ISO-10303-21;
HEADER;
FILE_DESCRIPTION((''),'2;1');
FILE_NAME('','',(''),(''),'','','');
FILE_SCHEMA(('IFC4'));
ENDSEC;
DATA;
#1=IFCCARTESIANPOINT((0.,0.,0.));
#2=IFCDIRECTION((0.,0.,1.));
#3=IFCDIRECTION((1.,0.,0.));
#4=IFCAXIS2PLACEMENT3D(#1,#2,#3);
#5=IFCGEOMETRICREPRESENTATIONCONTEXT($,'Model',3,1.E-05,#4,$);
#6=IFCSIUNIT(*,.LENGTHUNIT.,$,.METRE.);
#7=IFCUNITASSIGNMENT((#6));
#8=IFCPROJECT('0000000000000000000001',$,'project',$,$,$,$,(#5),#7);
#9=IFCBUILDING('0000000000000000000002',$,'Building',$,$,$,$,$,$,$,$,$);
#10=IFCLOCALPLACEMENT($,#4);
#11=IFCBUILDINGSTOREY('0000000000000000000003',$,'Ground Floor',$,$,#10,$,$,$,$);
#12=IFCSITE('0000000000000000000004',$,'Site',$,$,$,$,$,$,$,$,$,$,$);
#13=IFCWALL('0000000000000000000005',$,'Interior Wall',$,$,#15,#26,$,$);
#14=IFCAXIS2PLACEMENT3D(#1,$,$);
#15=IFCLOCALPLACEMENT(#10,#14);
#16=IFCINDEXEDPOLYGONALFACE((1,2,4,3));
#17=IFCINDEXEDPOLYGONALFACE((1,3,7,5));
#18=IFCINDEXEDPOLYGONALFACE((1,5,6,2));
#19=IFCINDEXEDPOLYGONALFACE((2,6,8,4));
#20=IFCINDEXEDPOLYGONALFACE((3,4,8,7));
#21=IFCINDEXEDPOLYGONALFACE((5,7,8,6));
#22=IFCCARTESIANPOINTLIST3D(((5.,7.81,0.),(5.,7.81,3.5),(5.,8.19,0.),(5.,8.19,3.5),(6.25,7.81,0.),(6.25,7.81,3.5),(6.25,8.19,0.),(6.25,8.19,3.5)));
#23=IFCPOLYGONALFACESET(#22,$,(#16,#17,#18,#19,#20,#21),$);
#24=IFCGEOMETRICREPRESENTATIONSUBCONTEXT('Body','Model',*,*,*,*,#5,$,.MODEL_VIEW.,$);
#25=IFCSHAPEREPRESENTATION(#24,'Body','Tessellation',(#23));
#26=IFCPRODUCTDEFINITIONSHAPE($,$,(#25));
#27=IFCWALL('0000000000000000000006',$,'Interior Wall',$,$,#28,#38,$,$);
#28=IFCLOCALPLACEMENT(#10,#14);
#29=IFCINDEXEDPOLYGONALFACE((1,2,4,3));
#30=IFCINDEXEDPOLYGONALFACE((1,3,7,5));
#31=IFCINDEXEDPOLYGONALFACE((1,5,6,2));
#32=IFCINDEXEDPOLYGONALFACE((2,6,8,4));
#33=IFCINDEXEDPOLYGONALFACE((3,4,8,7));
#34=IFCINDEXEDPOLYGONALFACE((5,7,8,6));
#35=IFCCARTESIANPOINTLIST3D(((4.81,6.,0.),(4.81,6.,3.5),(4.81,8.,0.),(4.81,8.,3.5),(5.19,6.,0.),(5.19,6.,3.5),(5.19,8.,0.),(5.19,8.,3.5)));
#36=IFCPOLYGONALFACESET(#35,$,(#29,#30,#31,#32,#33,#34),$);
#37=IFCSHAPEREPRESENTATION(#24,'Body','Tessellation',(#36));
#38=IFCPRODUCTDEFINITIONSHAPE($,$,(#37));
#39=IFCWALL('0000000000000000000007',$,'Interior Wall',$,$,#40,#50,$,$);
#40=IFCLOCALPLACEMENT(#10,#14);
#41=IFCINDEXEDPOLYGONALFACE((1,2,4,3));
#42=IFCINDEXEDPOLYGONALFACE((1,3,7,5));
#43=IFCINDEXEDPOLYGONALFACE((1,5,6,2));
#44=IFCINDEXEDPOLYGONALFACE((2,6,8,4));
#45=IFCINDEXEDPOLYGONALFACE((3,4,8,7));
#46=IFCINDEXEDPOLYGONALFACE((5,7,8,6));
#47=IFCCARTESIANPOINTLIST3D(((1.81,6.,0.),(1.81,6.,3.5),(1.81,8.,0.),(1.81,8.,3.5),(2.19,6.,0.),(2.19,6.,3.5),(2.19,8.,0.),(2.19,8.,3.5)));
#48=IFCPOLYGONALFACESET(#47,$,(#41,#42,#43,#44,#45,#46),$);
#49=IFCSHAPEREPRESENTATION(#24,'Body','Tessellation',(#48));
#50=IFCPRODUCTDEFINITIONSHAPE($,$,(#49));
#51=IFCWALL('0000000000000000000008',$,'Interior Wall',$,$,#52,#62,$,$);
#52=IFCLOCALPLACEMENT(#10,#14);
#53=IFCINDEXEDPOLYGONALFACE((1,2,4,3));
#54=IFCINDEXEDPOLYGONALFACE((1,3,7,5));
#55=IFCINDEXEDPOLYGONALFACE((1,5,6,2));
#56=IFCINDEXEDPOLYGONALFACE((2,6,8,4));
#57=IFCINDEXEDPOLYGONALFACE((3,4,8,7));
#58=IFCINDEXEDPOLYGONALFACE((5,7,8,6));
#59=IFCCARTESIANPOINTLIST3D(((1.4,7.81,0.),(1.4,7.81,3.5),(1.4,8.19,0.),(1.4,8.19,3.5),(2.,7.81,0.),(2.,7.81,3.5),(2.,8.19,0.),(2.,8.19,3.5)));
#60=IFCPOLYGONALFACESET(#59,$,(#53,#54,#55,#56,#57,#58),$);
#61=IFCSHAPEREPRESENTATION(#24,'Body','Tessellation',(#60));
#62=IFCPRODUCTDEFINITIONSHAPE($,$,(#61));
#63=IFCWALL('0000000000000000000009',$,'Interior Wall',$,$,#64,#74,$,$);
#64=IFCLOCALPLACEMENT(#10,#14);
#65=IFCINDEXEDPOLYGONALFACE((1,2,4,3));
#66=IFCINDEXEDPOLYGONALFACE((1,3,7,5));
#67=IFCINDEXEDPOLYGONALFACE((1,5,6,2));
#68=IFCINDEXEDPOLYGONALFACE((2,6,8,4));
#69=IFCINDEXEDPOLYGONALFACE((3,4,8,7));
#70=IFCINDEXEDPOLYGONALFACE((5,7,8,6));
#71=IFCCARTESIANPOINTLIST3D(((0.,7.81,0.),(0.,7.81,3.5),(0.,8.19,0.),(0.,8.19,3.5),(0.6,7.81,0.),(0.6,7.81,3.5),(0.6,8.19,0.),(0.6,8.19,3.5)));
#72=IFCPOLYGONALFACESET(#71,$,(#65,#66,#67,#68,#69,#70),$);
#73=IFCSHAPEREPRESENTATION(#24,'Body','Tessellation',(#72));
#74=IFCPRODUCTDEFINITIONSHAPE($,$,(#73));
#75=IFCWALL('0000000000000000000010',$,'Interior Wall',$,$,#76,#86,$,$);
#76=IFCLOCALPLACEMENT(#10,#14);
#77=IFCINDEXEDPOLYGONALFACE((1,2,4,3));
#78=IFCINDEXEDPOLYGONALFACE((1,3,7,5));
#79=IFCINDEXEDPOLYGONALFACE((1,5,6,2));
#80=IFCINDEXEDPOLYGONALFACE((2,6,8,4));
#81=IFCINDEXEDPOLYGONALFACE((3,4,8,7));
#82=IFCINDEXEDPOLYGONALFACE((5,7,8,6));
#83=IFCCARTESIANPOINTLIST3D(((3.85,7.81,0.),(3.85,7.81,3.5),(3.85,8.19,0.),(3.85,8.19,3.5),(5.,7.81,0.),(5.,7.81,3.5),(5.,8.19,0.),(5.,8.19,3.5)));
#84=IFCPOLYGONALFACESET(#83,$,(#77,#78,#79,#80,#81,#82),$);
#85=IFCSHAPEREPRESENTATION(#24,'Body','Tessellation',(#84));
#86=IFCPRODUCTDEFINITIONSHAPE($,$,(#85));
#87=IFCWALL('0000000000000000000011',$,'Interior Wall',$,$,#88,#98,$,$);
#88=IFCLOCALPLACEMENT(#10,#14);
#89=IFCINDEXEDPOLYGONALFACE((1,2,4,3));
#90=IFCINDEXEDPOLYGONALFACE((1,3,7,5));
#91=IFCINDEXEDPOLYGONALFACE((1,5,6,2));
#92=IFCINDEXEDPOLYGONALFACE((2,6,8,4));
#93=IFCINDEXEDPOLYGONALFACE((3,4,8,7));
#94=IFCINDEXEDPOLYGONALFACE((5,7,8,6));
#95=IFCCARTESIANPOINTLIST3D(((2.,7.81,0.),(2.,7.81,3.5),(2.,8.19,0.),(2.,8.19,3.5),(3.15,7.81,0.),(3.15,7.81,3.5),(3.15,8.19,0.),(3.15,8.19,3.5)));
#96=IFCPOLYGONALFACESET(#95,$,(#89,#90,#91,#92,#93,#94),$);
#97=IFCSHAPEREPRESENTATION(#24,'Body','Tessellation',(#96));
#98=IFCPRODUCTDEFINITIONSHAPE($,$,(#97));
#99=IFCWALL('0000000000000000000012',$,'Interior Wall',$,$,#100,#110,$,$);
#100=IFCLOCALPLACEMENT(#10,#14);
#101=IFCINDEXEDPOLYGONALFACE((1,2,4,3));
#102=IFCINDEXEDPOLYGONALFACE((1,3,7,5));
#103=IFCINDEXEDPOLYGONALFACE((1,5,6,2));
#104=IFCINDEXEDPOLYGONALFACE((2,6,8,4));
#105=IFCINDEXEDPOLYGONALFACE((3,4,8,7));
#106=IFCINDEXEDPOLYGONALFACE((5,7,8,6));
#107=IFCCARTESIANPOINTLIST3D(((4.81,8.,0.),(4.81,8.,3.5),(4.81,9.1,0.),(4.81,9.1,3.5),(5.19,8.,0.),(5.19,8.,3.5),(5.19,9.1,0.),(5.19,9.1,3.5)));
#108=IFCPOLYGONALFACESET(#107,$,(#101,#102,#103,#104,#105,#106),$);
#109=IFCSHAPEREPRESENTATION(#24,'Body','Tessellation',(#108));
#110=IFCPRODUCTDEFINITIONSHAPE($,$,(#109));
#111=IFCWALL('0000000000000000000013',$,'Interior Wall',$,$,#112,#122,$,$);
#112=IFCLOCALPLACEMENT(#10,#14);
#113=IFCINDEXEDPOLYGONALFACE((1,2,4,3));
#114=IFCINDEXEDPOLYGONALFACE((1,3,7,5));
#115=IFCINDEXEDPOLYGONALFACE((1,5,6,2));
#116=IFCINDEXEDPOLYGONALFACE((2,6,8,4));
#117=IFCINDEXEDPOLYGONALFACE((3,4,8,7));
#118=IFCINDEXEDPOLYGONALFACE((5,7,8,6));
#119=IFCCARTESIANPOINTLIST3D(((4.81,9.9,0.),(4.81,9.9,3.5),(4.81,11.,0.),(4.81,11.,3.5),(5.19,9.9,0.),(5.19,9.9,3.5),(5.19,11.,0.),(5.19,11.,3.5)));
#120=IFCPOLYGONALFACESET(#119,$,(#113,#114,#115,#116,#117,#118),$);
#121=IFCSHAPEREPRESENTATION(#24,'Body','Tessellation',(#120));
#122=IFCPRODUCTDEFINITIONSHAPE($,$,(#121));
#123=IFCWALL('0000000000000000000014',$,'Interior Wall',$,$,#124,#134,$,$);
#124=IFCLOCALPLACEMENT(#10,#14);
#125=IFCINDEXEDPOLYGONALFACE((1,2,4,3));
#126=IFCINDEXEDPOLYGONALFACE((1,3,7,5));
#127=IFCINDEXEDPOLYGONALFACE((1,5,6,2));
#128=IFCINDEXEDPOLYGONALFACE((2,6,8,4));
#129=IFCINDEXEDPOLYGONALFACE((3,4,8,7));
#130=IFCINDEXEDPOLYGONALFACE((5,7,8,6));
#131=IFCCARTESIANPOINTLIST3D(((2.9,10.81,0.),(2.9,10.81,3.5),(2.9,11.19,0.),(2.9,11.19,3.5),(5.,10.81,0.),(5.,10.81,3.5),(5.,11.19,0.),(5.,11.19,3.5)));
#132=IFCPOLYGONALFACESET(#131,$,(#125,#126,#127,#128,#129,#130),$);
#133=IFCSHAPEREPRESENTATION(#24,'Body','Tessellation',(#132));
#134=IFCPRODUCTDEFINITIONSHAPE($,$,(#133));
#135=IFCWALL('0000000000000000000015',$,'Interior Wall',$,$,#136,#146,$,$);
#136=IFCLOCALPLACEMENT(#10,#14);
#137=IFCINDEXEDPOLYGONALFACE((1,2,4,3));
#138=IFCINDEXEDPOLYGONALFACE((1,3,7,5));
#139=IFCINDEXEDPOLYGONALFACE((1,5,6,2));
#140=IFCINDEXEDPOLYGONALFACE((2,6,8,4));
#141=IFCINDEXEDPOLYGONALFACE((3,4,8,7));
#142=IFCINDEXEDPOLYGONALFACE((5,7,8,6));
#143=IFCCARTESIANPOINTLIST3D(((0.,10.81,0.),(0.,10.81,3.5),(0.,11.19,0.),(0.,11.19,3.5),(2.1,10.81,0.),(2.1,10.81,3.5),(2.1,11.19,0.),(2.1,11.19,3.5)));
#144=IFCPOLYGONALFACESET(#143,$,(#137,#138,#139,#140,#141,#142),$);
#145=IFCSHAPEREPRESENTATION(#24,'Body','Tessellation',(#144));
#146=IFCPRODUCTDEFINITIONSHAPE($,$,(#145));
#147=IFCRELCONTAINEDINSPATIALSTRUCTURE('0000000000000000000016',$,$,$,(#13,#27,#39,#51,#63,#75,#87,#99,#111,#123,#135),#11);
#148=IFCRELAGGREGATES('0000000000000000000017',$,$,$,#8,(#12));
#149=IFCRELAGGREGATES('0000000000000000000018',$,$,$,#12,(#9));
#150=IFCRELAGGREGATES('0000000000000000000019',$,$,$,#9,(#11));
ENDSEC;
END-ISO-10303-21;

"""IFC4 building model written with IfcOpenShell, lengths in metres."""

from ifc_helpers import new_model, si_unit, frame, origin_with_axes, place, context, subcontext, project, spatial, indexed_curve, outline, extrude, element, save


model = new_model("IFC4")

# Units and contexts
model_context = context("Model", 3, precision=1e-05, world=origin_with_axes())
body_context = subcontext(model_context, "Body", "Model", "MODEL_VIEW")
ifc_project = project(units=[si_unit("LENGTHUNIT", "METRE")], contexts=[model_context])

# Site, building, storey
site = spatial("IfcSite", under=ifc_project, Name="Site")
building = spatial("IfcBuilding", under=site, Name="Building")
storey_placement = place(None, origin_with_axes())
storey = spatial("IfcBuildingStorey", under=building, at=storey_placement, Name="Ground Floor")

# Walls
wall_1_placement = place(storey_placement, frame((6.25, 8.0, 0.0), z_axis=(0.0, 0.0, 1.0), x_axis=(-1.0, 0.0, 0.0)))
element("IfcWall", 1, at=wall_1_placement, inside=storey, Name="Interior Wall", context=body_context, shape_type="SweptSolid", body=[
    extrude(outline(indexed_curve([(0.0, 0.0), (0.0, 0.38), (1.25, 0.38), (1.25, 0.0), (0.0, 0.0)], self_intersect=False)), frame((0.0, -0.19, 0.0), z_axis=(0.0, 0.0, 1.0), x_axis=(1.0, 0.0, 0.0)), (0.0, 0.0, 1.0), 3.5),
])
for number, where, z_axis, x_axis, name in (
    (2, (5.0, 8.0, 0.0), (0.0, 0.0, 1.0), (0.0, -1.0, 0.0), "Interior Wall"),
    (3, (2.0, 6.0, 0.0), (0.0, 0.0, 1.0), (0.0, 1.0, 0.0), "Interior Wall"),
):
    element("IfcWall", number, at=place(storey_placement, frame(where, z_axis=z_axis, x_axis=x_axis)), inside=storey, Name=name, context=body_context, shape_type="SweptSolid", body=[
        extrude(outline(indexed_curve([(0.0, 0.0), (0.0, 0.38), (2.0, 0.38), (2.0, 0.0), (0.0, 0.0)], self_intersect=False)), frame((0.0, -0.19, 0.0), z_axis=(0.0, 0.0, 1.0), x_axis=(1.0, 0.0, 0.0)), (0.0, 0.0, 1.0), 3.5),
    ])
for number, where, z_axis, x_axis, name in (
    (4, (2.0, 8.0, 0.0), (0.0, 0.0, 1.0), (-1.0, 0.0, 0.0), "Interior Wall"),
    (5, (0.6, 8.0, 0.0), (0.0, 0.0, 1.0), (-1.0, 0.0, 0.0), "Interior Wall"),
):
    element("IfcWall", number, at=place(storey_placement, frame(where, z_axis=z_axis, x_axis=x_axis)), inside=storey, Name=name, context=body_context, shape_type="SweptSolid", body=[
        extrude(outline(indexed_curve([(0.0, 0.0), (0.0, 0.38), (0.6, 0.38), (0.6, 0.0), (0.0, 0.0)], self_intersect=False)), frame((0.0, -0.19, 0.0), z_axis=(0.0, 0.0, 1.0), x_axis=(1.0, 0.0, 0.0)), (0.0, 0.0, 1.0), 3.5),
    ])
for number, where, z_axis, x_axis, name in (
    (6, (5.0, 8.0, 0.0), (0.0, 0.0, 1.0), (-1.0, 0.0, 0.0), "Interior Wall"),
    (7, (3.15, 8.0, 0.0), (0.0, 0.0, 1.0), (-1.0, 0.0, 0.0), "Interior Wall"),
):
    element("IfcWall", number, at=place(storey_placement, frame(where, z_axis=z_axis, x_axis=x_axis)), inside=storey, Name=name, context=body_context, shape_type="SweptSolid", body=[
        extrude(outline(indexed_curve([(0.0, 0.0), (0.0, 0.38), (1.15, 0.38), (1.15, 0.0), (0.0, 0.0)], self_intersect=False)), frame((0.0, -0.19, 0.0), z_axis=(0.0, 0.0, 1.0), x_axis=(1.0, 0.0, 0.0)), (0.0, 0.0, 1.0), 3.5),
    ])
for number, where, z_axis, x_axis, name in (
    (8, (5.0, 8.0, 0.0), (0.0, 0.0, 1.0), (0.0, 1.0, 0.0), "Interior Wall"),
    (9, (5.0, 9.9, 0.0), (0.0, 0.0, 1.0), (0.0, 1.0, 0.0), "Interior Wall"),
):
    element("IfcWall", number, at=place(storey_placement, frame(where, z_axis=z_axis, x_axis=x_axis)), inside=storey, Name=name, context=body_context, shape_type="SweptSolid", body=[
        extrude(outline(indexed_curve([(0.0, 0.0), (0.0, 0.38), (1.1, 0.38), (1.1, 0.0), (0.0, 0.0)], self_intersect=False)), frame((0.0, -0.19, 0.0), z_axis=(0.0, 0.0, 1.0), x_axis=(1.0, 0.0, 0.0)), (0.0, 0.0, 1.0), 3.5),
    ])
for number, where, z_axis, x_axis, name in (
    (10, (5.0, 11.0, 0.0), (0.0, 0.0, 1.0), (-1.0, 0.0, 0.0), "Interior Wall"),
    (11, (2.1, 11.0, 0.0), (0.0, 0.0, 1.0), (-1.0, 0.0, 0.0), "Interior Wall"),
):
    element("IfcWall", number, at=place(storey_placement, frame(where, z_axis=z_axis, x_axis=x_axis)), inside=storey, Name=name, context=body_context, shape_type="SweptSolid", body=[
        extrude(outline(indexed_curve([(0.0, 0.0), (0.0, 0.38), (2.1, 0.38), (2.1, 0.0), (0.0, 0.0)], self_intersect=False)), frame((0.0, -0.19, 0.0), z_axis=(0.0, 0.0, 1.0), x_axis=(1.0, 0.0, 0.0)), (0.0, 0.0, 1.0), 3.5),
    ])

save(model, "model.ifc")
